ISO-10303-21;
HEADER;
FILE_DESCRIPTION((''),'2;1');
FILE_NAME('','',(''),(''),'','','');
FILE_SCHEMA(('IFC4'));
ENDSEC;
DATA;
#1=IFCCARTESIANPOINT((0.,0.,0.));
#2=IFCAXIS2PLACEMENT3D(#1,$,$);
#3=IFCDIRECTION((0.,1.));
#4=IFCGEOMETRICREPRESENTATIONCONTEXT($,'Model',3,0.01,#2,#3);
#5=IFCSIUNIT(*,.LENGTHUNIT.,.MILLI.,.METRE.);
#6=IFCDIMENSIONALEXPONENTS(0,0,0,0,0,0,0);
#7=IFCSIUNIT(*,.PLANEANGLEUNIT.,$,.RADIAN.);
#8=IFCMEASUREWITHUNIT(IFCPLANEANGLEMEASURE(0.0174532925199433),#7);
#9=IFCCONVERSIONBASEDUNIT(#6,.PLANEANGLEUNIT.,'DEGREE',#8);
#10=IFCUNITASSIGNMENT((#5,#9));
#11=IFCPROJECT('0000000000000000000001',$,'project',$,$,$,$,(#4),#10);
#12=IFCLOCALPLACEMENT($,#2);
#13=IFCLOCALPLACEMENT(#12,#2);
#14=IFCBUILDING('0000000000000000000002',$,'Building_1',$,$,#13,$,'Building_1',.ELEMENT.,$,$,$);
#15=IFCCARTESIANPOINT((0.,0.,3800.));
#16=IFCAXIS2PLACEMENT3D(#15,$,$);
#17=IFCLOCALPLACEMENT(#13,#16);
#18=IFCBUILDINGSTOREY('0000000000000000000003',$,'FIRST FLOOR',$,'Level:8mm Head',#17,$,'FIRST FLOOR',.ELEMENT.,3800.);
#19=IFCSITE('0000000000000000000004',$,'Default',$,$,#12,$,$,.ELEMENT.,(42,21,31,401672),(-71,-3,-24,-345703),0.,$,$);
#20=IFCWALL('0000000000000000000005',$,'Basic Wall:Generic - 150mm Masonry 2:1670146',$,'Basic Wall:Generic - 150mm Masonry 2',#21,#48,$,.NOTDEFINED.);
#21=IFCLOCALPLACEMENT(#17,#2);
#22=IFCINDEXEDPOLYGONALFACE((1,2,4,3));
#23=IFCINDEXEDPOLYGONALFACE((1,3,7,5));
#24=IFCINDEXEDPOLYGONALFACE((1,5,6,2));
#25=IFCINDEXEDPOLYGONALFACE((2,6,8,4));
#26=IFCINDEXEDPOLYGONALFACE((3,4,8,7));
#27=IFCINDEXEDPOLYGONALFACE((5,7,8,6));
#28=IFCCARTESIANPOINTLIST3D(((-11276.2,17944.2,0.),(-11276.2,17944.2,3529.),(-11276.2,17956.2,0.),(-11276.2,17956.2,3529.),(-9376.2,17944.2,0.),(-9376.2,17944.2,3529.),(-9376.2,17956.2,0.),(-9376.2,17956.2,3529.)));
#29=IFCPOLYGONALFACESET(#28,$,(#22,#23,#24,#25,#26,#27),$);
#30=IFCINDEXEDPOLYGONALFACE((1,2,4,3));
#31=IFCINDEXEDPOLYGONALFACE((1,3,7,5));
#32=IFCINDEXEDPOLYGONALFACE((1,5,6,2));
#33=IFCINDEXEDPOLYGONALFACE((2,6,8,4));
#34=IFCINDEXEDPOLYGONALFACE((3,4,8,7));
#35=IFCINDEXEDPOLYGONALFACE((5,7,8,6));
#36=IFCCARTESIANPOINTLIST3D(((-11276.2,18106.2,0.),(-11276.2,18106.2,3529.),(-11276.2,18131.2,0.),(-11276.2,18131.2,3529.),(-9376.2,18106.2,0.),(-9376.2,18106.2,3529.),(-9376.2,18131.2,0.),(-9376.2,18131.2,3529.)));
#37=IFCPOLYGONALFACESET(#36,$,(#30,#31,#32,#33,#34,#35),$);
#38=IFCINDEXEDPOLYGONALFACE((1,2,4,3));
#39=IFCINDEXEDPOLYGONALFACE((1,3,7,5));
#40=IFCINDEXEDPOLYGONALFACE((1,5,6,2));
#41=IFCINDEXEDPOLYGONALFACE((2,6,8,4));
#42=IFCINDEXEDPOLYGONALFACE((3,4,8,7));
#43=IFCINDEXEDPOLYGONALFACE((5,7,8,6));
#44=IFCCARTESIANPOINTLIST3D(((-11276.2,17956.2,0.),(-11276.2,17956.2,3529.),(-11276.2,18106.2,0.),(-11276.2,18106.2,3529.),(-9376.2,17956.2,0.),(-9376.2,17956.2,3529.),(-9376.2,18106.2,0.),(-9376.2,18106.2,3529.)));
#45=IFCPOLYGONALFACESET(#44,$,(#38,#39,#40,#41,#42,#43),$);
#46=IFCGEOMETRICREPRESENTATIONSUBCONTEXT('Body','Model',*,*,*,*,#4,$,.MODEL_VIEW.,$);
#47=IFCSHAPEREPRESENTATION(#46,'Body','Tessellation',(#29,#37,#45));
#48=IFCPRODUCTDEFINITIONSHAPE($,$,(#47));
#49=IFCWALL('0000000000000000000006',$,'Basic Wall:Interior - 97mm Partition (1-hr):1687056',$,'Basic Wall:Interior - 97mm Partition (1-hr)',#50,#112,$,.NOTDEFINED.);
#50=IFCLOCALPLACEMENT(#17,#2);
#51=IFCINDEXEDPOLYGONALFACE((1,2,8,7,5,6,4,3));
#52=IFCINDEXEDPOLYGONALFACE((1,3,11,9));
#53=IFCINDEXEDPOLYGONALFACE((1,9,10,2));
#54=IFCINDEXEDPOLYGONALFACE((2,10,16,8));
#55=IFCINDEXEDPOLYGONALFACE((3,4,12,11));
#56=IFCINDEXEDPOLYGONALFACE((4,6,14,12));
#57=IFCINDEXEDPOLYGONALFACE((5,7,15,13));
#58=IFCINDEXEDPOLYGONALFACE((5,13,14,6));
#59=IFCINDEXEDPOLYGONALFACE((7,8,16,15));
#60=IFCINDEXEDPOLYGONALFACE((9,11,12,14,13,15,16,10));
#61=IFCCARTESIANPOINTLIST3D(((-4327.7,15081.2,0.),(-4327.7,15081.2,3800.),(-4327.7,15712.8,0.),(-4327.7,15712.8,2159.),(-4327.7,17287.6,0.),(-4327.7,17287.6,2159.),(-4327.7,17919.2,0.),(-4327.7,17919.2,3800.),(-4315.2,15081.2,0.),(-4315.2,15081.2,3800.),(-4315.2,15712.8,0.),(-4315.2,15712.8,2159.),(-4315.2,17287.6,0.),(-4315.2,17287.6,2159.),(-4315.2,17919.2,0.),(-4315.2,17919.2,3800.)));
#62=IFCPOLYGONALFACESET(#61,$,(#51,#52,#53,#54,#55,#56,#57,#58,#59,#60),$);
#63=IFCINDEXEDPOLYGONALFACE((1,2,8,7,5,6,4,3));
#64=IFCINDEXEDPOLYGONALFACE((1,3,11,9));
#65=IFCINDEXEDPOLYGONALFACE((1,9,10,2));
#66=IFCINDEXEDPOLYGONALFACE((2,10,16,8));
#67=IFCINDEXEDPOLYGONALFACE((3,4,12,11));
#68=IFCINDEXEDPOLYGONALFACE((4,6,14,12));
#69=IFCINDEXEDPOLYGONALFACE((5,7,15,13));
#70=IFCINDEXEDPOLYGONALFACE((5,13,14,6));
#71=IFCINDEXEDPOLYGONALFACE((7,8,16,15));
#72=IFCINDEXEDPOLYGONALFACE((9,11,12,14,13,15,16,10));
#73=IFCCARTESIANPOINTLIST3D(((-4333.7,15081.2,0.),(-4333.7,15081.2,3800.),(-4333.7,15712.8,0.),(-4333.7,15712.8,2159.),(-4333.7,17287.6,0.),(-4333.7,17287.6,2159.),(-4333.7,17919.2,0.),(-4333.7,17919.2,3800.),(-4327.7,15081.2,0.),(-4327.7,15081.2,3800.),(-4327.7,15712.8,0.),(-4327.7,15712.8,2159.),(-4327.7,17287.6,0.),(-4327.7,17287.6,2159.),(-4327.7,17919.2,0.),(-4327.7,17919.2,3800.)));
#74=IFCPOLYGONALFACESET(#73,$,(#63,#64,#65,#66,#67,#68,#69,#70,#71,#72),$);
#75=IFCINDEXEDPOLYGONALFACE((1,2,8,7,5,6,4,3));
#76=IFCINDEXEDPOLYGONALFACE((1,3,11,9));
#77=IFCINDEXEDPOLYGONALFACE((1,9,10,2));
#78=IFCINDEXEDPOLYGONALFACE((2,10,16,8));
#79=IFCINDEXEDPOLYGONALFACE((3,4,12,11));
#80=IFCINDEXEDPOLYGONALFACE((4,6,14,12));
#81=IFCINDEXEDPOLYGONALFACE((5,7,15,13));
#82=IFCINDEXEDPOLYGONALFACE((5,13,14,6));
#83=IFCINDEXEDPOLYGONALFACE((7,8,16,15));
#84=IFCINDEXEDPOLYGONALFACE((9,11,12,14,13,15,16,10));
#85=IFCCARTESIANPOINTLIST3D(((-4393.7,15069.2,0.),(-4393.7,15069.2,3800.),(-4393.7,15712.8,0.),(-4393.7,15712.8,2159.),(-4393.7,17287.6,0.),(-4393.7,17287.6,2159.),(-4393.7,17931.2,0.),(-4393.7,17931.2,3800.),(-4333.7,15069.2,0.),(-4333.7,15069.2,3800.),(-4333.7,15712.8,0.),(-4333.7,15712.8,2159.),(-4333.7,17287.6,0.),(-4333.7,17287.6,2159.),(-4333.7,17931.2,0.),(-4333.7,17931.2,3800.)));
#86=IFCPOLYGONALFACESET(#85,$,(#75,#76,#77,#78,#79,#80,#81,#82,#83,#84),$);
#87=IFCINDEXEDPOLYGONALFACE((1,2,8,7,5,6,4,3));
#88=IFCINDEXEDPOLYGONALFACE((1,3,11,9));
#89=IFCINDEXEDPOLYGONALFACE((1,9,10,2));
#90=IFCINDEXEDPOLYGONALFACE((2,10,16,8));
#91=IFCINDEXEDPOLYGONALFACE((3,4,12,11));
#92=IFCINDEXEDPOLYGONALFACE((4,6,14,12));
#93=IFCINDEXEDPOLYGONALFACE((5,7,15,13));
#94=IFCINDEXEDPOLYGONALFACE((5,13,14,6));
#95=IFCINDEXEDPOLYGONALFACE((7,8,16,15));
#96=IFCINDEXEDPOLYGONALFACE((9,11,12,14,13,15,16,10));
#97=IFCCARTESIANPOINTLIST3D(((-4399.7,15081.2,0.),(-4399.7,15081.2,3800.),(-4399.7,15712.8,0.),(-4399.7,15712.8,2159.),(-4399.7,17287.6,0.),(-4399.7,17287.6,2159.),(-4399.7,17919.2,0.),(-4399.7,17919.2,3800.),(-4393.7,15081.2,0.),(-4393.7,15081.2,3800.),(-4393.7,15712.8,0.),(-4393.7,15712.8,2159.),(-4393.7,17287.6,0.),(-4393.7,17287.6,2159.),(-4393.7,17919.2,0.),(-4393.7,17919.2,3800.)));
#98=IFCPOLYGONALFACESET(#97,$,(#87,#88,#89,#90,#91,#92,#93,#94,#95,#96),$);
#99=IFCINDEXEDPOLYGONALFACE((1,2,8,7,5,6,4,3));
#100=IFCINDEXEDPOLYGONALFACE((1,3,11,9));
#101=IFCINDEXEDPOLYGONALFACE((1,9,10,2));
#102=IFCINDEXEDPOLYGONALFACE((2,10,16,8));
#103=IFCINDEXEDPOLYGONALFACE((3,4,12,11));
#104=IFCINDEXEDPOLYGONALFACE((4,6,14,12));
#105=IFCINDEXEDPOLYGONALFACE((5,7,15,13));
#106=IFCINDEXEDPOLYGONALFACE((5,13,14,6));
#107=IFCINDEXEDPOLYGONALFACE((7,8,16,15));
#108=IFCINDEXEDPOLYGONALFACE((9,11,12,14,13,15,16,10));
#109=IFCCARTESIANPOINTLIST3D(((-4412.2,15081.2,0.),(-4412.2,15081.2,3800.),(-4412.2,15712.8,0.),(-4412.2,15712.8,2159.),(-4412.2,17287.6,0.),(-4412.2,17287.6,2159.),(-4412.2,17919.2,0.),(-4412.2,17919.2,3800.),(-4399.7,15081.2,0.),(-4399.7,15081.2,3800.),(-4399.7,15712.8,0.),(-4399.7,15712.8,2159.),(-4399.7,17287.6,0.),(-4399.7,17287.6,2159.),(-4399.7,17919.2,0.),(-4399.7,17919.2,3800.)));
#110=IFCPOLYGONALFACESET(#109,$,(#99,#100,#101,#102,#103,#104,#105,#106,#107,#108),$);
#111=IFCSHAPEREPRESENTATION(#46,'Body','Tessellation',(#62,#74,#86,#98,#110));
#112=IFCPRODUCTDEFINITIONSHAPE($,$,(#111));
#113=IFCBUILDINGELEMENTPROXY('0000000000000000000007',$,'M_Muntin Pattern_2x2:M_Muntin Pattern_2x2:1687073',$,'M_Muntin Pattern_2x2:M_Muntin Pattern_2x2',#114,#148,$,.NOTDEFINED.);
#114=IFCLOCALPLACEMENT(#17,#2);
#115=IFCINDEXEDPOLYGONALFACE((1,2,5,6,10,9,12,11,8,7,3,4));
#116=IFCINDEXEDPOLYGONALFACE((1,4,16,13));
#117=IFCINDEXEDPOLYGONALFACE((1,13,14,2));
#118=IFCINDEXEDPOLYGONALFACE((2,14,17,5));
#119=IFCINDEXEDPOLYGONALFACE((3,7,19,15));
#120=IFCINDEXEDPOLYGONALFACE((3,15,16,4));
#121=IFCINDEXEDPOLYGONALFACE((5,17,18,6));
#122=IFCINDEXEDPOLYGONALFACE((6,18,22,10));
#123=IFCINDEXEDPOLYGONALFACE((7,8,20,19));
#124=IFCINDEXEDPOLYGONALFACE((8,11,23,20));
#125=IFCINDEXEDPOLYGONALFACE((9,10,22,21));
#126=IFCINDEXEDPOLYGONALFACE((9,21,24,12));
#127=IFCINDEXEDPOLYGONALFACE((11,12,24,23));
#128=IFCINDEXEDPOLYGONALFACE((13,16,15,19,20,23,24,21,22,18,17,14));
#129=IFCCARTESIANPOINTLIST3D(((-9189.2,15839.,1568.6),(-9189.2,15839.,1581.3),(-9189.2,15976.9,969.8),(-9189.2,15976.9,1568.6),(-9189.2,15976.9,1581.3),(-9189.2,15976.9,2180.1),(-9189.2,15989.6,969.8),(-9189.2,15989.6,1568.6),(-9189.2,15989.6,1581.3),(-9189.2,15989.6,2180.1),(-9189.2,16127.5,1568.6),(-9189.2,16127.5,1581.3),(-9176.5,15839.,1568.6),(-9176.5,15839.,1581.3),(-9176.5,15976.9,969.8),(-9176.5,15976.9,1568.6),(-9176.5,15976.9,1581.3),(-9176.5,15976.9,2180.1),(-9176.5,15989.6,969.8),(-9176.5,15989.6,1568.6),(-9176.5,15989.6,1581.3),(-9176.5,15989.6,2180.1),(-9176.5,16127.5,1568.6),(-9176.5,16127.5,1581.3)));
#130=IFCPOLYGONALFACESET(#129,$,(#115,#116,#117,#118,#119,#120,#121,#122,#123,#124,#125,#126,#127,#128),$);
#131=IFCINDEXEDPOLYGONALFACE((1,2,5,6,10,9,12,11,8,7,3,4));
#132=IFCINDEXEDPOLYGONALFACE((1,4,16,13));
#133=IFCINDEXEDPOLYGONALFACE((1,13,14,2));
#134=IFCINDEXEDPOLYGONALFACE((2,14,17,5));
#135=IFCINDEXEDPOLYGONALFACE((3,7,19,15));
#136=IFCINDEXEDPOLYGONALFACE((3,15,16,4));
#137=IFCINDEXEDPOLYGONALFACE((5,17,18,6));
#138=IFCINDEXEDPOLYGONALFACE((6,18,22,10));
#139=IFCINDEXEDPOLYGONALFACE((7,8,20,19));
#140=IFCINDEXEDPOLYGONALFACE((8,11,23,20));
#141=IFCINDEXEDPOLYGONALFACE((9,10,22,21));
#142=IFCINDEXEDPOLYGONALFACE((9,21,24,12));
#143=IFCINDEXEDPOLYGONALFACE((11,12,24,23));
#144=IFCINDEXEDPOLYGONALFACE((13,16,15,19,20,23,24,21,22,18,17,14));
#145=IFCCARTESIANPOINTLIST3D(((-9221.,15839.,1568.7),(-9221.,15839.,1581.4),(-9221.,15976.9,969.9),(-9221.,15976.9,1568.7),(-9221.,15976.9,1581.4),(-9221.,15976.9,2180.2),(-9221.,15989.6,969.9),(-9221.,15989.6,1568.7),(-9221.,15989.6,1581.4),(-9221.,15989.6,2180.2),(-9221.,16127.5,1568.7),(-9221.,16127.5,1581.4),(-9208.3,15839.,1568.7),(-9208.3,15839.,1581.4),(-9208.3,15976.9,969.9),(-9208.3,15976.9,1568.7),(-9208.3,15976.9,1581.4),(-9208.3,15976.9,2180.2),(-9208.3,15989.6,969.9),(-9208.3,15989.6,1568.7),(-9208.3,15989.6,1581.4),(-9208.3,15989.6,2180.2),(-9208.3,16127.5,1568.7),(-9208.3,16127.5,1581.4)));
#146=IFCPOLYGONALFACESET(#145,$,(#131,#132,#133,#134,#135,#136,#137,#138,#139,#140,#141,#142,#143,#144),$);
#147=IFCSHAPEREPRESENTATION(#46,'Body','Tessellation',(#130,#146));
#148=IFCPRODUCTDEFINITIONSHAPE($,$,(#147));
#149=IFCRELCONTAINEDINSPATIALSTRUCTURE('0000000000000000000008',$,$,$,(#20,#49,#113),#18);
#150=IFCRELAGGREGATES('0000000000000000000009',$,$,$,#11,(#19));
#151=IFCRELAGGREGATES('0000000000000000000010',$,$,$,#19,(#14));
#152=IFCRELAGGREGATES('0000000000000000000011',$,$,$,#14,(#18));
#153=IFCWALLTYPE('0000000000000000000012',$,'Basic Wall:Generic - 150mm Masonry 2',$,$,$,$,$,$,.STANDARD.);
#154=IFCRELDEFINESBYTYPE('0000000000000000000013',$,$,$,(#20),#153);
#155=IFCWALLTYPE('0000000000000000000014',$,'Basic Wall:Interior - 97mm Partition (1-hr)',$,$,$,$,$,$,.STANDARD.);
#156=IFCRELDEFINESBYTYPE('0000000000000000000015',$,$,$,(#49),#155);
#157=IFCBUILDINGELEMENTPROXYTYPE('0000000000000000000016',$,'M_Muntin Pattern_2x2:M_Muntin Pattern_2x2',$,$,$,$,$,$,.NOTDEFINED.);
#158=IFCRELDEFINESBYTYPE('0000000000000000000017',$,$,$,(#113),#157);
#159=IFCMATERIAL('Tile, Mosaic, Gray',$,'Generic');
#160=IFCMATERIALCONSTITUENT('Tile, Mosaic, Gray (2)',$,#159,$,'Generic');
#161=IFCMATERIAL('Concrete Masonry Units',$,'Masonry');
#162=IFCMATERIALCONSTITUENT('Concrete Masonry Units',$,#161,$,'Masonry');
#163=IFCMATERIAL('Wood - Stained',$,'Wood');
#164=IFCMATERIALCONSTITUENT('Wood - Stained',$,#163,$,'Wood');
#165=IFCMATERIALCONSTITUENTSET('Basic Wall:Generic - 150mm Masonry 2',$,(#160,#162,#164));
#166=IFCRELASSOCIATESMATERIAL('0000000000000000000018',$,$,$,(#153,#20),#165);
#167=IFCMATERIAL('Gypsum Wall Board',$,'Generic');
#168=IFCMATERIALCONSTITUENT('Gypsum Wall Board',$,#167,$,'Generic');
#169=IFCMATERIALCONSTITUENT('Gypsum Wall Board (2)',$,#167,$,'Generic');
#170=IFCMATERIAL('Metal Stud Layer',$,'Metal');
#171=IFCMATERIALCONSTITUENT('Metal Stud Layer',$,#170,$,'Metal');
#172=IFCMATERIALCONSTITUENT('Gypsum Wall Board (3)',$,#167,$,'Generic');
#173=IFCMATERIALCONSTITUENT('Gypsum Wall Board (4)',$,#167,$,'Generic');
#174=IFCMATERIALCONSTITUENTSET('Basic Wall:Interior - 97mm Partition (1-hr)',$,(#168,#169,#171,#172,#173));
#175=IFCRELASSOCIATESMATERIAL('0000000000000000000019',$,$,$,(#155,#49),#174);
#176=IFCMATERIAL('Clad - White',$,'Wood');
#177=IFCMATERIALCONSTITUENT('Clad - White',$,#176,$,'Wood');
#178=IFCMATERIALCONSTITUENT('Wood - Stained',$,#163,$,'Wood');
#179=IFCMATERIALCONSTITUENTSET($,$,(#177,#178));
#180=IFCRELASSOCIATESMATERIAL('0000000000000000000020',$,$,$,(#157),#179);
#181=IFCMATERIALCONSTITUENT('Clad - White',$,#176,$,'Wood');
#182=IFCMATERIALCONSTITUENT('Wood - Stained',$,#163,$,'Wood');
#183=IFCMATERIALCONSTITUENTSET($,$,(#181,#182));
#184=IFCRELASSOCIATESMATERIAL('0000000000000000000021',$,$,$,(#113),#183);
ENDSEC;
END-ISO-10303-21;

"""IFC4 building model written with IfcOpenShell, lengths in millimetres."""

from ifc_helpers import new_model, entity, si_unit, converted_unit, direction, frame, origin, place, context, subcontext, project, spatial, indexed_curve, outline, extrude, source, transform, mapped, material, constituent, constituent_set, type_object, type_shapes, element, save


model = new_model("IFC4")

# Units and contexts
model_context = context("Model", 3, precision=0.01, world=origin(), true_north=direction((0.0, 1.0)))
body_context = subcontext(model_context, "Body", "Model", "MODEL_VIEW")
ifc_project = project(units=[si_unit("LENGTHUNIT", "METRE", prefix="MILLI"), converted_unit("PLANEANGLEUNIT", "DEGREE", entity("IfcPlaneAngleMeasure", 0.0174532925199433), si_unit("PLANEANGLEUNIT", "RADIAN"), dimensions=[0, 0, 0, 0, 0, 0, 0])], contexts=[model_context])

# Site, building, storey
site_placement = place(None, origin())
site = spatial("IfcSite", under=ifc_project, at=site_placement, Name="Default", CompositionType="ELEMENT", RefLatitude=(42, 21, 31, 401672), RefLongitude=(-71, -3, -24, -345703), RefElevation=0.0)
building_placement = place(site_placement, origin())
building = spatial("IfcBuilding", under=site, at=building_placement, Name="Building_1", LongName="Building_1", CompositionType="ELEMENT")
storey_placement = place(building_placement, frame((0.0, 0.0, 3800.0)))
storey = spatial("IfcBuildingStorey", under=building, at=storey_placement, Name="FIRST FLOOR", ObjectType="Level:8mm Head", LongName="FIRST FLOOR", CompositionType="ELEMENT", Elevation=3800.0)

# Shared definitions
ifc_material_1 = material(Name="Tile, Mosaic, Gray", Category="Generic")
ifc_constituent_1 = constituent(ifc_material_1, Name="Tile, Mosaic, Gray (2)", Category="Generic")
ifc_material_2 = material(Name="Concrete Masonry Units", Category="Masonry")
ifc_constituent_2 = constituent(ifc_material_2, Name="Concrete Masonry Units", Category="Masonry")
ifc_material_3 = material(Name="Wood - Stained", Category="Wood")
ifc_constituent_3 = constituent(ifc_material_3, Name="Wood - Stained", Category="Wood")
ifc_constituent_set_1 = constituent_set(constituents=[ifc_constituent_1, ifc_constituent_2, ifc_constituent_3], Name="Basic Wall:Generic - 150mm Masonry 2")
wall_type_1 = type_object("IfcWallType", Name="Basic Wall:Generic - 150mm Masonry 2", PredefinedType="STANDARD", material=ifc_constituent_set_1)

# Wall
wall_1_placement = place(storey_placement, frame((-11276.2, 18037.7, 0.0)))
element("IfcWall", 1, at=wall_1_placement, inside=storey, type_object=wall_type_1, material=ifc_constituent_set_1, Name="Basic Wall:Generic - 150mm Masonry 2:1670146", ObjectType="Basic Wall:Generic - 150mm Masonry 2", PredefinedType="NOTDEFINED", context=body_context, shape_type="SweptSolid", body=[
    extrude(outline(indexed_curve([(-6.0, -950.0), (6.0, -950.0), (6.0, 950.0), (-6.0, 950.0), (-6.0, -950.0)], self_intersect=False)), frame((950.0, -87.5, 0.0), z_axis=(0.0, 0.0, 1.0), x_axis=(0.0, 1.0, 0.0)), (0.0, 0.0, 1.0), 3529.0),
    extrude(outline(indexed_curve([(-12.5, -950.0), (12.5, -950.0), (12.5, 950.0), (-12.5, 950.0), (-12.5, -950.0)], self_intersect=False)), frame((950.0, 81.0, 0.0), z_axis=(0.0, 0.0, 1.0), x_axis=(0.0, -1.0, 0.0)), (0.0, 0.0, 1.0), 3529.0),
    extrude(outline(indexed_curve([(-950.0, -75.0), (950.0, -75.0), (950.0, 75.0), (-950.0, 75.0), (-950.0, -75.0)], self_intersect=False)), frame((950.0, -6.5, 0.0)), (0.0, 0.0, 1.0), 3529.0),
])

# Wall, opening
ifc_material_4 = material(Name="Gypsum Wall Board", Category="Generic")
ifc_constituent_4 = constituent(ifc_material_4, Name="Gypsum Wall Board", Category="Generic")
ifc_constituent_5 = constituent(ifc_material_4, Name="Gypsum Wall Board (2)", Category="Generic")
ifc_material_5 = material(Name="Metal Stud Layer", Category="Metal")
ifc_constituent_6 = constituent(ifc_material_5, Name="Metal Stud Layer", Category="Metal")
ifc_constituent_7 = constituent(ifc_material_4, Name="Gypsum Wall Board (3)", Category="Generic")
ifc_constituent_8 = constituent(ifc_material_4, Name="Gypsum Wall Board (4)", Category="Generic")
ifc_constituent_set_2 = constituent_set(constituents=[ifc_constituent_4, ifc_constituent_5, ifc_constituent_6, ifc_constituent_7, ifc_constituent_8], Name="Basic Wall:Interior - 97mm Partition (1-hr)")
wall_type_2 = type_object("IfcWallType", Name="Basic Wall:Interior - 97mm Partition (1-hr)", PredefinedType="STANDARD", material=ifc_constituent_set_2)
wall_2_placement = place(storey_placement, frame((-4363.7, 15081.2, 0.0), z_axis=(0.0, 0.0, 1.0), x_axis=(0.0, 1.0, 0.0)))
wall_2 = element("IfcWall", 2, at=wall_2_placement, inside=storey, type_object=wall_type_2, material=ifc_constituent_set_2, Name="Basic Wall:Interior - 97mm Partition (1-hr):1687056", ObjectType="Basic Wall:Interior - 97mm Partition (1-hr)", PredefinedType="NOTDEFINED", context=body_context, shape_type="SweptSolid", body=[
    extrude(outline(indexed_curve([(-1489.8, -1419.0), (2310.2, -1419.0), (2310.2, 1419.0), (-1489.8, 1419.0), (-1489.8, 787.4), (669.3, 787.4), (669.3, -787.4), (-1489.8, -787.4), (-1489.8, -1419.0)], self_intersect=False)), frame((1419.0, -36.0, 1489.8), z_axis=(0.0, -1.0, 0.0), x_axis=(0.0, 0.0, 1.0)), (0.0, 0.0, 1.0), 12.5),
    extrude(outline(indexed_curve([(-1489.8, -1419.0), (2310.2, -1419.0), (2310.2, 1419.0), (-1489.8, 1419.0), (-1489.8, 787.4), (669.2, 787.4), (669.2, -787.4), (-1489.8, -787.4), (-1489.8, -1419.0)], self_intersect=False)), frame((1419.0, -30.0, 1489.8), z_axis=(0.0, -1.0, 0.0), x_axis=(0.0, 0.0, 1.0)), (0.0, 0.0, 1.0), 6.0),
    extrude(outline(indexed_curve([(-1489.8, -1431.0), (2310.2, -1431.0), (2310.2, 1431.0), (-1489.8, 1431.0), (-1489.8, 787.4), (669.3, 787.4), (669.2, -787.4), (-1489.8, -787.4), (-1489.8, -1431.0)], self_intersect=False)), frame((1419.0, 30.0, 1489.8), z_axis=(0.0, -1.0, 0.0), x_axis=(0.0, 0.0, 1.0)), (0.0, 0.0, 1.0), 60.0),
    extrude(outline(indexed_curve([(-1489.8, -1419.0), (2310.2, -1419.0), (2310.2, 1419.0), (-1489.8, 1419.0), (-1489.8, 787.4), (669.3, 787.4), (669.3, -787.4), (-1489.8, -787.4), (-1489.8, -1419.0)], self_intersect=False)), frame((1419.0, 36.0, 1489.8), z_axis=(0.0, -1.0, 0.0), x_axis=(0.0, 0.0, 1.0)), (0.0, 0.0, 1.0), 6.0),
    extrude(outline(indexed_curve([(-2310.2, -1419.0), (1489.8, -1419.0), (1489.8, -787.4), (-669.3, -787.4), (-669.3, 787.4), (1489.8, 787.4), (1489.8, 1419.0), (-2310.2, 1419.0), (-2310.2, -1419.0)], self_intersect=False)), frame((1419.0, 48.5, 1489.8), z_axis=(0.0, -1.0, 0.0), x_axis=(0.0, 0.0, -1.0)), (0.0, 0.0, 1.0), 12.5),
])
opening_1_placement = place(wall_2_placement, frame((2206.4, 48.5, 0.0)))
element("IfcOpeningElement", 3, at=opening_1_placement, cuts=wall_2, PredefinedType="OPENING", context=body_context, shape_type="SweptSolid", body=[
    extrude(outline(indexed_curve([(0.0, 1574.8), (0.0, 0.0), (2159.0, 0.0), (2159.0, 1574.8), (0.0, 1574.8)], self_intersect=False)), frame((0.0, 0.0, 0.0), z_axis=(0.0, -1.0, 0.0), x_axis=(0.0, 0.0, 1.0)), (0.0, 0.0, 1.0), 97.0),
])

# Building element proxy
ifc_material_6 = material(Name="Clad - White", Category="Wood")
ifc_constituent_9 = constituent(ifc_material_6, Name="Clad - White", Category="Wood")
ifc_constituent_10 = constituent(ifc_material_3, Name="Wood - Stained", Category="Wood")
ifc_constituent_set_3 = constituent_set(constituents=[ifc_constituent_9, ifc_constituent_10])
ifc_constituent_11 = constituent(ifc_material_6, Name="Clad - White", Category="Wood")
ifc_constituent_12 = constituent(ifc_material_3, Name="Wood - Stained", Category="Wood")
ifc_constituent_set_4 = constituent_set(constituents=[ifc_constituent_11, ifc_constituent_12])
building_element_proxy_type_1 = type_object("IfcBuildingElementProxyType", Name="M_Muntin Pattern_2x2:M_Muntin Pattern_2x2", PredefinedType="NOTDEFINED", material=ifc_constituent_set_4)
shared_shape_1 = source(origin(), body_context, "Body", "SweptSolid", [
    extrude(outline(indexed_curve([(6.4, -6.4), (605.1, -6.4), (605.1, 6.3), (6.4, 6.3), (6.4, 144.2), (-6.3, 144.2), (-6.3, 6.3), (-605.2, 6.3), (-605.2, -6.4), (-6.3, -6.4), (-6.3, -144.2), (6.4, -144.2), (6.4, -6.4)], self_intersect=False)), frame((0.0, -22.2, 605.1), z_axis=(0.0, 1.0, 0.0), x_axis=(0.0, 0.0, 1.0)), (0.0, 0.0, 1.0), 12.7),
    extrude(outline(indexed_curve([(6.4, -6.4), (605.2, -6.4), (605.2, 6.3), (6.4, 6.3), (6.4, 144.2), (-6.3, 144.2), (-6.3, 6.3), (-605.2, 6.3), (-605.2, -6.4), (-6.3, -6.4), (-6.3, -144.2), (6.4, -144.2), (6.4, -6.4)], self_intersect=False)), frame((0.0, 9.5, 605.2), z_axis=(0.0, 1.0, 0.0), x_axis=(0.0, 0.0, 1.0)), (0.0, 0.0, 1.0), 12.7),
])
type_shapes(building_element_proxy_type_1, [shared_shape_1])
proxy_1_placement = place(storey_placement, frame((-9198.7, 15983.3, 969.9), z_axis=(0.0, 0.0, 1.0), x_axis=(0.0, 1.0, 0.0)))
element("IfcBuildingElementProxy", 4, at=proxy_1_placement, inside=storey, type_object=building_element_proxy_type_1, material=ifc_constituent_set_3, Name="M_Muntin Pattern_2x2:M_Muntin Pattern_2x2:1687073", ObjectType="M_Muntin Pattern_2x2:M_Muntin Pattern_2x2", PredefinedType="NOTDEFINED", context=body_context, shape_type="MappedRepresentation", body=[
    mapped(shared_shape_1, transform((0.0, 0.0, 0.0), scale=1.0)),
])

save(model, "model.ifc")
